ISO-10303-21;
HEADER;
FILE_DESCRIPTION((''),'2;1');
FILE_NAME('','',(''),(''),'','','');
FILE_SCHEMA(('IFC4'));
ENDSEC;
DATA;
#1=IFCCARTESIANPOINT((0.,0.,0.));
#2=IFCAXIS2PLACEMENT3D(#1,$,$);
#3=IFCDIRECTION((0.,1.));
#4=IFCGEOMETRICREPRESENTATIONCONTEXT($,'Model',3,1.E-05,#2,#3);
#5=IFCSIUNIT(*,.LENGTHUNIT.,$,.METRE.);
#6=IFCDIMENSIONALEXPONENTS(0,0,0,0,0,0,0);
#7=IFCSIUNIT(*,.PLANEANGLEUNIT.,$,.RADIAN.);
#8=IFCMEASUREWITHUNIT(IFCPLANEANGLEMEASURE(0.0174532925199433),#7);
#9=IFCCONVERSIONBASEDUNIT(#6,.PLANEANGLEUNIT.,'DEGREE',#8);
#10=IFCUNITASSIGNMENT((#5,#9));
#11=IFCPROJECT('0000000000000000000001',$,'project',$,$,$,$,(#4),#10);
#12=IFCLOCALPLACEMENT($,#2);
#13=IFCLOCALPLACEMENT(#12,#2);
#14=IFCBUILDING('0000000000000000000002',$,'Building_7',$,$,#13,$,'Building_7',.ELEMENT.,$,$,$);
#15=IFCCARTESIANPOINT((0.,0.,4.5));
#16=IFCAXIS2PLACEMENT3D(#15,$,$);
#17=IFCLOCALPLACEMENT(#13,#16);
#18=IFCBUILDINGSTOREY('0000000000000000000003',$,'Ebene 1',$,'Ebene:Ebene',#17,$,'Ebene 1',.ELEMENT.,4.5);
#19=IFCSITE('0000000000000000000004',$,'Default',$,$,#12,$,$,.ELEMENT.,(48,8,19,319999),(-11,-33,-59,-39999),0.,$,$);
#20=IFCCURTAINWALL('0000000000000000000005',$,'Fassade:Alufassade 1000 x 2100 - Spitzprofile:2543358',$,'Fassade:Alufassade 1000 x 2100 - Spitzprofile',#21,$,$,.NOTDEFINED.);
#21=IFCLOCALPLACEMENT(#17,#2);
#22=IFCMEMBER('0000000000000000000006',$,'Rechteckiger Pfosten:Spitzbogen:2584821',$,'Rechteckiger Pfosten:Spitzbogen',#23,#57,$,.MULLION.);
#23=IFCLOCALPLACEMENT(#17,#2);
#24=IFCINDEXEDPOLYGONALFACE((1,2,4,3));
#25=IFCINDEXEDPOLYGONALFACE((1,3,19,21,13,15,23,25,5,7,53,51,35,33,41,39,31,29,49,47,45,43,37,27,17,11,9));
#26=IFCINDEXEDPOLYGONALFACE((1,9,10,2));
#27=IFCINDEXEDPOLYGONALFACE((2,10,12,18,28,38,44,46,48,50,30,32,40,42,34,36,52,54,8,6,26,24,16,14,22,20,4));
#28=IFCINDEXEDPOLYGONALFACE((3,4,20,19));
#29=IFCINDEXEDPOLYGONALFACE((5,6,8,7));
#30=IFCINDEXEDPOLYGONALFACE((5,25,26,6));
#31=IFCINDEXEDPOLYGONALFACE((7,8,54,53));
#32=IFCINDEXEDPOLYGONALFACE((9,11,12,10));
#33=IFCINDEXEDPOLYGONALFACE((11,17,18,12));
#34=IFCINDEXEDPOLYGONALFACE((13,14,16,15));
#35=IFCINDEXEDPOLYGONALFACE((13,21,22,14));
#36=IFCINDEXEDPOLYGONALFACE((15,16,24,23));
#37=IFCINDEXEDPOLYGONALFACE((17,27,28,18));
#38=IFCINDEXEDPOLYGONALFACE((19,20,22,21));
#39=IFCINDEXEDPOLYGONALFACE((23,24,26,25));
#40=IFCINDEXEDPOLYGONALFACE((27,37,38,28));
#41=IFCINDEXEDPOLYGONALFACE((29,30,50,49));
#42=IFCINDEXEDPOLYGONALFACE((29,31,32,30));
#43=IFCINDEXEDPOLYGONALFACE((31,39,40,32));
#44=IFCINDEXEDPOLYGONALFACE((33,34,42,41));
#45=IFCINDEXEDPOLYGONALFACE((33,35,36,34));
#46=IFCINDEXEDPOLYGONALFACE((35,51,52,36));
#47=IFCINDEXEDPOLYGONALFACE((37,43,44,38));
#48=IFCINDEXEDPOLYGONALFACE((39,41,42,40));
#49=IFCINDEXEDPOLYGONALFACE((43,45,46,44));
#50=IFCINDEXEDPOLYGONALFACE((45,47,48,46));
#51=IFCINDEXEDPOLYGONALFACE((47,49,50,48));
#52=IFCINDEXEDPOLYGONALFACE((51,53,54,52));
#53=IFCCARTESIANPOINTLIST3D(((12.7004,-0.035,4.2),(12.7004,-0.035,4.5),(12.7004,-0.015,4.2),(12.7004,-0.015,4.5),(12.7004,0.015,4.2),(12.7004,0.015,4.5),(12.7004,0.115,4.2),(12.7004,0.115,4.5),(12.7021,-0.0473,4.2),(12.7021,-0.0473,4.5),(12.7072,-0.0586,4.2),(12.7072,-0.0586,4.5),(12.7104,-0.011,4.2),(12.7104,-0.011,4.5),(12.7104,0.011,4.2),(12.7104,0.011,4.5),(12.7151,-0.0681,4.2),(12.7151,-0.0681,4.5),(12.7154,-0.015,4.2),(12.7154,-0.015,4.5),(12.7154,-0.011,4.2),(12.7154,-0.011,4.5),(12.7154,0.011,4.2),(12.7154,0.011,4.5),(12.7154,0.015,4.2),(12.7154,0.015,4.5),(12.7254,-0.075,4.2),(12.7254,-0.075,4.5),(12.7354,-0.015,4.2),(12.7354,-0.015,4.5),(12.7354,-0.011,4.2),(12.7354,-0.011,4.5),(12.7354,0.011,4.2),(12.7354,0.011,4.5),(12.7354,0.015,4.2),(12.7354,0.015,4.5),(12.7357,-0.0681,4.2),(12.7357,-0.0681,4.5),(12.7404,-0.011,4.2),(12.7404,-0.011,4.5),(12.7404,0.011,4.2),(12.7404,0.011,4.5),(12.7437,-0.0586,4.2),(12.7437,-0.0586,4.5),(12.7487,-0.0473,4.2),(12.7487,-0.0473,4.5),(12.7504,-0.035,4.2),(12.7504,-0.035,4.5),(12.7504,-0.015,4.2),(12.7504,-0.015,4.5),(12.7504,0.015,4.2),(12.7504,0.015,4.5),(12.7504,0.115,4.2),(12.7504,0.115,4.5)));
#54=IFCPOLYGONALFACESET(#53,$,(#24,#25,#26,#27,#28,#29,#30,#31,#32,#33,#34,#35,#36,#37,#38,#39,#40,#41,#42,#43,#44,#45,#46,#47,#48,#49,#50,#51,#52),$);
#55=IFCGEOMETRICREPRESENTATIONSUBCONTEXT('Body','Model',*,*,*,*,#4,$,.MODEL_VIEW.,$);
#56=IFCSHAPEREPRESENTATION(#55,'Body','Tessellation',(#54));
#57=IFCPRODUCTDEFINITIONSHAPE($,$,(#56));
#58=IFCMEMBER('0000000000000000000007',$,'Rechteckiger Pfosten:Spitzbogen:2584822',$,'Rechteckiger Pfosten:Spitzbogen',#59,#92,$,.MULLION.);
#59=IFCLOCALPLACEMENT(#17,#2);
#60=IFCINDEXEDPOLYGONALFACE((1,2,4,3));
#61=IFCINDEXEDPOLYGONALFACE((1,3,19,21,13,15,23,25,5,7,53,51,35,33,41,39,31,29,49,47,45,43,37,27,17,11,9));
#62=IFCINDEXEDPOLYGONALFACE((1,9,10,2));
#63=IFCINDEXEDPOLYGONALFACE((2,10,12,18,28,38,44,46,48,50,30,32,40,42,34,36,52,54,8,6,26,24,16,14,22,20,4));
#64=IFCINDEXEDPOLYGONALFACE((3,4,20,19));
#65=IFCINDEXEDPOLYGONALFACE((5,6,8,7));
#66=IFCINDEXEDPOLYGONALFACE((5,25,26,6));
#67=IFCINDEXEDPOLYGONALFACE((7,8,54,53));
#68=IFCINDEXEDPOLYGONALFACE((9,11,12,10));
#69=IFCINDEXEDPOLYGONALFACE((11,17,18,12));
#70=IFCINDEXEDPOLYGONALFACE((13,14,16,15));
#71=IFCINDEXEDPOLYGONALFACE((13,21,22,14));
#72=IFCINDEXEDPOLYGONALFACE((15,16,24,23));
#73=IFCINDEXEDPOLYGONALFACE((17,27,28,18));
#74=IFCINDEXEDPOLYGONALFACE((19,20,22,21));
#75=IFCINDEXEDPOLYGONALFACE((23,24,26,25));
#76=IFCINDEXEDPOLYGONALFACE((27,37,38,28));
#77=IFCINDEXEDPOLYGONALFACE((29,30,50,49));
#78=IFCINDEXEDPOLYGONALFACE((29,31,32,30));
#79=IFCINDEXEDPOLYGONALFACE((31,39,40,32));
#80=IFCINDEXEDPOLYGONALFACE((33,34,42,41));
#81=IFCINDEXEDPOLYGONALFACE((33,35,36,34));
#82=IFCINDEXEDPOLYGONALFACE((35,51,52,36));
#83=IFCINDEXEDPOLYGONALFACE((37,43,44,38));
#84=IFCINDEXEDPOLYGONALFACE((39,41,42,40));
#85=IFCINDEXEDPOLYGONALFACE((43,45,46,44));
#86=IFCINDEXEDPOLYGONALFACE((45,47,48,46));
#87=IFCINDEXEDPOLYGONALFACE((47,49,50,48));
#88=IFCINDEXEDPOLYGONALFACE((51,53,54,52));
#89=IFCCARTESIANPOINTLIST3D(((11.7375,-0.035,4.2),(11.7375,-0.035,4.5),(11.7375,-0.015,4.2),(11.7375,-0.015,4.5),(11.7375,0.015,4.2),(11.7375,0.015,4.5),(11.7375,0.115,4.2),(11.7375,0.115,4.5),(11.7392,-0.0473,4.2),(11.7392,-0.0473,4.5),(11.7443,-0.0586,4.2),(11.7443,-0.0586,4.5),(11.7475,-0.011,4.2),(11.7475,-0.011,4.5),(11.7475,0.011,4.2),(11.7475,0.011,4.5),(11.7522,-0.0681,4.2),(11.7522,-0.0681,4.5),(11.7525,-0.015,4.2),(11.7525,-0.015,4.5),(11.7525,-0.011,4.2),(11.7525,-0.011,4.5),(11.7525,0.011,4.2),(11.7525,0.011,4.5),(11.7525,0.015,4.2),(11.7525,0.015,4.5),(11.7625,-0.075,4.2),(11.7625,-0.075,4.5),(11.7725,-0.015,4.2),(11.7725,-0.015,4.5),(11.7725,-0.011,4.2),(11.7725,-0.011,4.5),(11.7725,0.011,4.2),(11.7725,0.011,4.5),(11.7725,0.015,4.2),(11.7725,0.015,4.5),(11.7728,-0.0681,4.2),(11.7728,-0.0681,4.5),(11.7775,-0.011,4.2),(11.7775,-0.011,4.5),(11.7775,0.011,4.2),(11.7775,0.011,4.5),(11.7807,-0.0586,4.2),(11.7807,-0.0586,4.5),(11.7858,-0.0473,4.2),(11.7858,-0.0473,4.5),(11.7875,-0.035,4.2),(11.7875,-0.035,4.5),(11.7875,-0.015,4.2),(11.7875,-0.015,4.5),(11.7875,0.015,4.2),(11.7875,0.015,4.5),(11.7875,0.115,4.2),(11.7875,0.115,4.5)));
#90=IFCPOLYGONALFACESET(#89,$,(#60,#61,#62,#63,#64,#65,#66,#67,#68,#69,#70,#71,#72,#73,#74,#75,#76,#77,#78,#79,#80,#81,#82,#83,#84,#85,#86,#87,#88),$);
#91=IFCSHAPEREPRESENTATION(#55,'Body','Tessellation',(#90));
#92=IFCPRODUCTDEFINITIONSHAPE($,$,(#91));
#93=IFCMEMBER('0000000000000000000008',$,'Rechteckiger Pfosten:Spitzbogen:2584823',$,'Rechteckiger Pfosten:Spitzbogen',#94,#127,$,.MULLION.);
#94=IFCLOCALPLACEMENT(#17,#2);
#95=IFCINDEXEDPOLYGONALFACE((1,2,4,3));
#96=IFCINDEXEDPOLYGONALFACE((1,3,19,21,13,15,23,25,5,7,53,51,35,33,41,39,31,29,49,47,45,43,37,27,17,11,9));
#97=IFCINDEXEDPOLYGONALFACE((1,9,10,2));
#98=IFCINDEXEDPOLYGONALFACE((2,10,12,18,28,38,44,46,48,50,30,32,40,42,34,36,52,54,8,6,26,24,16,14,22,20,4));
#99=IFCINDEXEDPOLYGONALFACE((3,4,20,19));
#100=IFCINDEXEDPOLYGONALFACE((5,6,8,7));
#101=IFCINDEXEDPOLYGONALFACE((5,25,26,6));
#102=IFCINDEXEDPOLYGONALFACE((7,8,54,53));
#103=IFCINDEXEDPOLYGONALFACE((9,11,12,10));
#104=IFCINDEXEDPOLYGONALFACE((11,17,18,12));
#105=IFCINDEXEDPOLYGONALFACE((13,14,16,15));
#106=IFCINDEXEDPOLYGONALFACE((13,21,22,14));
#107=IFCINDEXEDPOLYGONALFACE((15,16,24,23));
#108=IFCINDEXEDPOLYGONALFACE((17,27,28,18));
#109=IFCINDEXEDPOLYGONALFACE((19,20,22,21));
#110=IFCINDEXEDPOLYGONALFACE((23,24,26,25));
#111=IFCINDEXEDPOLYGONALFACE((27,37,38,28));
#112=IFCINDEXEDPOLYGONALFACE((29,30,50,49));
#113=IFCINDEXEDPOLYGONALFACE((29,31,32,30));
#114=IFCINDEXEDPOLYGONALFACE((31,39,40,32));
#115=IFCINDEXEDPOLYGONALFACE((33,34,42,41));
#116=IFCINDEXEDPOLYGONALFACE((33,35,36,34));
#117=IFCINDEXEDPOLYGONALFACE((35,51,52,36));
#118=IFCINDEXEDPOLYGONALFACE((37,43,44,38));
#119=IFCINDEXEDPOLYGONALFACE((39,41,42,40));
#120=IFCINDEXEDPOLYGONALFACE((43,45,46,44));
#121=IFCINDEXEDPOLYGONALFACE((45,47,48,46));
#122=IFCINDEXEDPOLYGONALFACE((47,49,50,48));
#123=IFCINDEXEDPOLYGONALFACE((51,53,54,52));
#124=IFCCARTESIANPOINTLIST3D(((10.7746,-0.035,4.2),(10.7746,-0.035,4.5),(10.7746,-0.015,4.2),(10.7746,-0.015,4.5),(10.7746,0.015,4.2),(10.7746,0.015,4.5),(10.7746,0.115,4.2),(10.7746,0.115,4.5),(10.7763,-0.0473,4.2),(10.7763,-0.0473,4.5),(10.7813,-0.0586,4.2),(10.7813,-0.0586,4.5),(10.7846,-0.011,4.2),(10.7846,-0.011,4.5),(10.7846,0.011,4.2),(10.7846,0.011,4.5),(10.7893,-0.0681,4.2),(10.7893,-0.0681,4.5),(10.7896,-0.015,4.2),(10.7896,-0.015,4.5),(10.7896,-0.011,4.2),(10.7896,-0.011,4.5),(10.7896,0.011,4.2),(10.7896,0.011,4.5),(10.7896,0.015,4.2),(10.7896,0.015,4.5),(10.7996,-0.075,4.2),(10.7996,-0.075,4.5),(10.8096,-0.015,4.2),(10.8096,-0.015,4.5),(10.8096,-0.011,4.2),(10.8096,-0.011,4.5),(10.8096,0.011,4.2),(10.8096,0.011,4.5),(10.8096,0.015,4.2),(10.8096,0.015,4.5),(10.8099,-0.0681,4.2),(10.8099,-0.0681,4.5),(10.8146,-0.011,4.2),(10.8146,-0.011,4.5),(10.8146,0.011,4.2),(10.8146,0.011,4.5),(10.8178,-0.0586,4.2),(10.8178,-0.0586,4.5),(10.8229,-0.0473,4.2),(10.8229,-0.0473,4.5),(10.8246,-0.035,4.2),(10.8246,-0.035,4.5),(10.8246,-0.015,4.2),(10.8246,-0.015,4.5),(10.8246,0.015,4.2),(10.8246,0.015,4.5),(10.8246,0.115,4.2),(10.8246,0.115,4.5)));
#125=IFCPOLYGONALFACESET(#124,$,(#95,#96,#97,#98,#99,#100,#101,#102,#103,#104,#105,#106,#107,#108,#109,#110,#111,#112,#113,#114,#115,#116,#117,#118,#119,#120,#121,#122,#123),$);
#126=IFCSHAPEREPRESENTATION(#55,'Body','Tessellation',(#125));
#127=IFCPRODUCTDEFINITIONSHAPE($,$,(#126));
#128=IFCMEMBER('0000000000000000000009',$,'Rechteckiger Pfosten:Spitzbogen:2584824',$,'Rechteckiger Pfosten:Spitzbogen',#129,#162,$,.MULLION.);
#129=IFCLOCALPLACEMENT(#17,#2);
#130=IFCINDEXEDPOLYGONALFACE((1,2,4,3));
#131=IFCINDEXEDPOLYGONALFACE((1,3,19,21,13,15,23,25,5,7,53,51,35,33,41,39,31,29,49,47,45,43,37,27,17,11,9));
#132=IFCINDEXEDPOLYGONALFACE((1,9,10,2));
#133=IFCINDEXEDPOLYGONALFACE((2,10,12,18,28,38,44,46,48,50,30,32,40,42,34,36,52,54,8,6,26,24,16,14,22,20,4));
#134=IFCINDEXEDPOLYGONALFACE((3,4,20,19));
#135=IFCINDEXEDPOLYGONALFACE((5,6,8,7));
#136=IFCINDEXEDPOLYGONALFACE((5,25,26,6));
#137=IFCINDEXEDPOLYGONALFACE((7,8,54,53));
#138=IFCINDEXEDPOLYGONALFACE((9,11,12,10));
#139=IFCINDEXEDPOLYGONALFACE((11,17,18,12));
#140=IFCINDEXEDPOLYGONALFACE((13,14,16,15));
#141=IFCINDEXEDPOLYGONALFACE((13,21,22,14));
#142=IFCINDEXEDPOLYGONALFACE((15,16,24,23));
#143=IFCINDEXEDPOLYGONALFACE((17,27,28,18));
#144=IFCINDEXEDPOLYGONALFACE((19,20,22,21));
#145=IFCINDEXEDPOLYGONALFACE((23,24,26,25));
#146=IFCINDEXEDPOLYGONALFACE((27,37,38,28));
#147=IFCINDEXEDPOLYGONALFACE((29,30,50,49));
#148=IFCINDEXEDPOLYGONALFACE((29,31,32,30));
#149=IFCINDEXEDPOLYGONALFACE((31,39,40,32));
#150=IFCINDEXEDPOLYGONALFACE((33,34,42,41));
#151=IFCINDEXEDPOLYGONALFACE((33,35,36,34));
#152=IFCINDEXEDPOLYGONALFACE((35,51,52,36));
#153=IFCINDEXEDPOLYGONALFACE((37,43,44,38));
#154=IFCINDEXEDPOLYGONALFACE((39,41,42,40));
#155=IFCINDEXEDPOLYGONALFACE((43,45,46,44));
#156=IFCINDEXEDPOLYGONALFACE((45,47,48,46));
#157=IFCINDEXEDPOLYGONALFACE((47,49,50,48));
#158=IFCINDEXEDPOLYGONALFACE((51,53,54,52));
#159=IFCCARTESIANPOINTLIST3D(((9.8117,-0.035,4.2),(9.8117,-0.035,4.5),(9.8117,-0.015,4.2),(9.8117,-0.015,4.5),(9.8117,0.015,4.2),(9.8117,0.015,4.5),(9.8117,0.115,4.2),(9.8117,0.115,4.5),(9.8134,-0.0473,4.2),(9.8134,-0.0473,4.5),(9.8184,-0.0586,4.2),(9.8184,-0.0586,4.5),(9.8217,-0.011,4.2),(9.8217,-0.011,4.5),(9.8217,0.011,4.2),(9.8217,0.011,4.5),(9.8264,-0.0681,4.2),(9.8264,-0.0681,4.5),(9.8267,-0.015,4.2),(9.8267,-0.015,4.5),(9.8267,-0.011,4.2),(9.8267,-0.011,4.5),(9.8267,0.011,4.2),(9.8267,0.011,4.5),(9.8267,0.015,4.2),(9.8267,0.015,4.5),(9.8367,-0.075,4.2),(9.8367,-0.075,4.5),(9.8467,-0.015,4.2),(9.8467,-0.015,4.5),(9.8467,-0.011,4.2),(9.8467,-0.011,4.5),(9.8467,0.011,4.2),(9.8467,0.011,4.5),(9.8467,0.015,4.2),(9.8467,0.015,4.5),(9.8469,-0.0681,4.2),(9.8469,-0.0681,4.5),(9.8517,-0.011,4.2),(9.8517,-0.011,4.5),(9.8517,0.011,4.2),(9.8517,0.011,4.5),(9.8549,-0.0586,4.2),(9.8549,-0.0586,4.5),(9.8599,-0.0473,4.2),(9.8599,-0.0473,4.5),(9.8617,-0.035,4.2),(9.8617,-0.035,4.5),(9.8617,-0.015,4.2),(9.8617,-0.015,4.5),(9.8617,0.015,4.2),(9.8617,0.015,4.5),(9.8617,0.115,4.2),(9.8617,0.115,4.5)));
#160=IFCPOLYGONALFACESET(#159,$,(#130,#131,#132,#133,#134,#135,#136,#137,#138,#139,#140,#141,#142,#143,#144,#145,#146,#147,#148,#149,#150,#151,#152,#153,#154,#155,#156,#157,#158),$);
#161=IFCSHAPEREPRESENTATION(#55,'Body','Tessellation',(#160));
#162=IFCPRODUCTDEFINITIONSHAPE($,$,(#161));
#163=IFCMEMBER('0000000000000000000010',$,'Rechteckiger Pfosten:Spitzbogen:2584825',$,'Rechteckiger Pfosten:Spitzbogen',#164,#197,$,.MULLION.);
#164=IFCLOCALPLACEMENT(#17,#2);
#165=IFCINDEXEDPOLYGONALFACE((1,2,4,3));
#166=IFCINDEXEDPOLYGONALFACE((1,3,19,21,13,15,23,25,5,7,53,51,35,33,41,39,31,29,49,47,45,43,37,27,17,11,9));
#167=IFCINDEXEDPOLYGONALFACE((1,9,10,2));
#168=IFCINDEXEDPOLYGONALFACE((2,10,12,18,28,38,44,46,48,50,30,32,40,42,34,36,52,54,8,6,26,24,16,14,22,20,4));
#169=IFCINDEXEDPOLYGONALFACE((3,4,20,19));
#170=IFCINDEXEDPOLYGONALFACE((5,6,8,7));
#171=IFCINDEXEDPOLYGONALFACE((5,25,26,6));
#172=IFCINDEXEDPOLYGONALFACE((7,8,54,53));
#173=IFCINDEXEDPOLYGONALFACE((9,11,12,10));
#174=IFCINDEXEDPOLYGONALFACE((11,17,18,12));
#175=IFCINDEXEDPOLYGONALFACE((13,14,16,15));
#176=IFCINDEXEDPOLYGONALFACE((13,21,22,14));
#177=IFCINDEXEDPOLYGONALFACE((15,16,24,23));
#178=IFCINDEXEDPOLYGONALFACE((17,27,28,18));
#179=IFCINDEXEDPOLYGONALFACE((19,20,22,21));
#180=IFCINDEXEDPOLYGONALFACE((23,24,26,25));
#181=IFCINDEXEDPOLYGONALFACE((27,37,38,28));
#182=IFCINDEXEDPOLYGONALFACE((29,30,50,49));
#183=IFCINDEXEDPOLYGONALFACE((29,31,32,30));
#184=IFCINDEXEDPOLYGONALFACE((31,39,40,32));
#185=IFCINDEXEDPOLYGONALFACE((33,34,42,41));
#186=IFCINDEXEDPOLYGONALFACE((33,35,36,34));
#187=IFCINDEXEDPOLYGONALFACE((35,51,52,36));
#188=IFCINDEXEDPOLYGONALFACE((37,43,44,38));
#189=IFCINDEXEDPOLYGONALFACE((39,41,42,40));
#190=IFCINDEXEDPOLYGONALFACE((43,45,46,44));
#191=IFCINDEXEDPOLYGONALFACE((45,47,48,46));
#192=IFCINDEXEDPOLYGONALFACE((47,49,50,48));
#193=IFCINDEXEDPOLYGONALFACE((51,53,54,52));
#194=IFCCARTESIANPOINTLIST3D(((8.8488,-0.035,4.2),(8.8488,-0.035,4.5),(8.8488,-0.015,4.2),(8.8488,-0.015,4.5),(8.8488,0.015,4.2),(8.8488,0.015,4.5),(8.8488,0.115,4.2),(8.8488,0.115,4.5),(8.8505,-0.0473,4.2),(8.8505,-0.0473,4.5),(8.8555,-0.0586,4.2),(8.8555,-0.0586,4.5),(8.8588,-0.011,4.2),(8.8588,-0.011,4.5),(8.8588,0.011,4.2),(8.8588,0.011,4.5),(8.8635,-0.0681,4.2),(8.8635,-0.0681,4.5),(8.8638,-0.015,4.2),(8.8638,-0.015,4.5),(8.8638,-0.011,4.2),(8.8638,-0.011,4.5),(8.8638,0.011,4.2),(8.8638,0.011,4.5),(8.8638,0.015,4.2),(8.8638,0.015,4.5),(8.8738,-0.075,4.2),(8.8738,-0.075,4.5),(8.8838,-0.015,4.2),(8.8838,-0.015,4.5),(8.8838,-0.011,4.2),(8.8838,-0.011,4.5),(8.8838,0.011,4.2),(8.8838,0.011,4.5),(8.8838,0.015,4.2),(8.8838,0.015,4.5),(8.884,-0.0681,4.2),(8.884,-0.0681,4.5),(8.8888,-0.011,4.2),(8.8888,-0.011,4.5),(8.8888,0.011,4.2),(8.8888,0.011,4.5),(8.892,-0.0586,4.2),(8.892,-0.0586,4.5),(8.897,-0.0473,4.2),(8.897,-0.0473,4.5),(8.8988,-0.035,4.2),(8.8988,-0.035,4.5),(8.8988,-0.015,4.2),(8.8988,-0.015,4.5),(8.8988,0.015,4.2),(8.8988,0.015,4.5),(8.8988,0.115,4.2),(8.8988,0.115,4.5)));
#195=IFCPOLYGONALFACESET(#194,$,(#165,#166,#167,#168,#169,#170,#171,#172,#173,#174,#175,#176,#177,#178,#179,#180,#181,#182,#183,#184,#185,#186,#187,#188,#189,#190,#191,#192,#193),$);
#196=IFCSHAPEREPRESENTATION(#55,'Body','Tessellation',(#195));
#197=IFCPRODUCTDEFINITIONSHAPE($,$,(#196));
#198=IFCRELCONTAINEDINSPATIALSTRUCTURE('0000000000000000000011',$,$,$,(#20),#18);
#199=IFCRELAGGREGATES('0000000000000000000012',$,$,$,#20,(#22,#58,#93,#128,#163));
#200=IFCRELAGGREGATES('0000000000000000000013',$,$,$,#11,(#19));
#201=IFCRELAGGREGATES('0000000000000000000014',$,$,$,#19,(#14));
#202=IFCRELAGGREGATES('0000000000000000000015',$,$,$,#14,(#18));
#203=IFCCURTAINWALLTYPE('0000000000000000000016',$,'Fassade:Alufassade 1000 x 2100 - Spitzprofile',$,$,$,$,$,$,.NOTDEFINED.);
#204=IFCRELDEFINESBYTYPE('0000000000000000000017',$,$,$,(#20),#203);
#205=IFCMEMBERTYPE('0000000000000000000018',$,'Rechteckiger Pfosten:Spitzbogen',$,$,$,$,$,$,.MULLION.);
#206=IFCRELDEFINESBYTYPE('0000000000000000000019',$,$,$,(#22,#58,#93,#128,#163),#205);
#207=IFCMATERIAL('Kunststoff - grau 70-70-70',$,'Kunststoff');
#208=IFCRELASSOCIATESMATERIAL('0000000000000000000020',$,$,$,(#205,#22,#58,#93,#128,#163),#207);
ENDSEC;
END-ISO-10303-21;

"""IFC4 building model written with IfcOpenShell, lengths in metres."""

from ifc_helpers import new_model, entity, si_unit, converted_unit, direction, frame, origin, place, context, subcontext, project, spatial, line, arc, indexed_curve, outline, extrude, source, transform, mapped, material, type_object, type_shapes, element, aggregate, save


model = new_model("IFC4")

# Units and contexts
model_context = context("Model", 3, precision=1e-05, world=origin(), true_north=direction((0.0, 1.0)))
body_context = subcontext(model_context, "Body", "Model", "MODEL_VIEW")
ifc_project = project(units=[si_unit("LENGTHUNIT", "METRE"), converted_unit("PLANEANGLEUNIT", "DEGREE", entity("IfcPlaneAngleMeasure", 0.0174532925199433), si_unit("PLANEANGLEUNIT", "RADIAN"), dimensions=[0, 0, 0, 0, 0, 0, 0])], contexts=[model_context])

# Site, building, storey
site_placement = place(None, origin())
site = spatial("IfcSite", under=ifc_project, at=site_placement, Name="Default", CompositionType="ELEMENT", RefLatitude=(48, 8, 19, 319999), RefLongitude=(-11, -33, -59, -39999), RefElevation=0.0)
building_placement = place(site_placement, origin())
building = spatial("IfcBuilding", under=site, at=building_placement, Name="Building_7", LongName="Building_7", CompositionType="ELEMENT")
storey_placement = place(building_placement, frame((0.0, 0.0, 4.5)))
storey = spatial("IfcBuildingStorey", under=building, at=storey_placement, Name="Ebene 1", ObjectType="Ebene:Ebene", LongName="Ebene 1", CompositionType="ELEMENT", Elevation=4.5)

# Curtain wall, members
curtain_wall_type = type_object("IfcCurtainWallType", Name="Fassade:Alufassade 1000 x 2100 - Spitzprofile", PredefinedType="NOTDEFINED")
curtain_wall_placement = place(storey_placement, frame((0.0, 0.0, -4.5)))
curtain_wall = element("IfcCurtainWall", 1, at=curtain_wall_placement, inside=storey, type_object=curtain_wall_type, Name="Fassade:Alufassade 1000 x 2100 - Spitzprofile:2543358", ObjectType="Fassade:Alufassade 1000 x 2100 - Spitzprofile", PredefinedType="NOTDEFINED")
ifc_material_1 = material(Name="Kunststoff - grau 70-70-70", Category="Kunststoff")
member_type_1 = type_object("IfcMemberType", Name="Rechteckiger Pfosten:Spitzbogen", PredefinedType="MULLION", material=ifc_material_1)
shared_shape_1 = source(origin(), body_context, "Body", "SweptSolid", [
    extrude(outline(indexed_curve([(-0.111, -0.025), (-0.011, -0.025), (-0.011, -0.01), (-0.007, -0.01), (-0.007, -0.015), (0.015, -0.015), (0.015, -0.01), (0.019, -0.01), (0.019, -0.025), (0.039, -0.025), (0.0626, -0.0182), (0.079, 0.0), (0.0626, 0.0182), (0.039, 0.025), (0.019, 0.025), (0.019, 0.01), (0.015, 0.01), (0.015, 0.015), (-0.007, 0.015), (-0.007, 0.01), (-0.011, 0.01), (-0.011, 0.025), (-0.111, 0.025)], segments=[line(1, 2, 3, 4, 5, 6, 7, 8, 9, 10), arc(10, 11, 12), arc(12, 13, 14), line(14, 15, 16, 17, 18, 19, 20, 21, 22, 23, 1)], self_intersect=False)), frame((0.0, 0.004, -0.3), z_axis=(0.0, 0.0, 1.0), x_axis=(0.0, -1.0, 0.0)), (0.0, 0.0, 1.0), 0.3),
])
type_shapes(member_type_1, [shared_shape_1])
member_1_placement = place(curtain_wall_placement, frame((12.7254, 0.0, 8.7), z_axis=(0.0, 0.0, -1.0), x_axis=(-1.0, 0.0, 0.0)))
member_1 = element("IfcMember", 2, at=member_1_placement, type_object=member_type_1, material=ifc_material_1, Name="Rechteckiger Pfosten:Spitzbogen:2584821", ObjectType="Rechteckiger Pfosten:Spitzbogen", PredefinedType="MULLION", context=body_context, shape_type="MappedRepresentation", body=[
    mapped(shared_shape_1, transform((0.0, 0.0, 0.0), scale=1.0)),
])
member_2_placement = place(curtain_wall_placement, frame((11.7625, 0.0, 8.7), z_axis=(0.0, 0.0, -1.0), x_axis=(-1.0, 0.0, 0.0)))
member_2 = element("IfcMember", 3, at=member_2_placement, type_object=member_type_1, material=ifc_material_1, Name="Rechteckiger Pfosten:Spitzbogen:2584822", ObjectType="Rechteckiger Pfosten:Spitzbogen", PredefinedType="MULLION", context=body_context, shape_type="MappedRepresentation", body=[
    mapped(shared_shape_1, transform((0.0, 0.0, 0.0), scale=1.0)),
])
member_3_placement = place(curtain_wall_placement, frame((10.7996, 0.0, 8.7), z_axis=(0.0, 0.0, -1.0), x_axis=(-1.0, 0.0, 0.0)))
member_3 = element("IfcMember", 4, at=member_3_placement, type_object=member_type_1, material=ifc_material_1, Name="Rechteckiger Pfosten:Spitzbogen:2584823", ObjectType="Rechteckiger Pfosten:Spitzbogen", PredefinedType="MULLION", context=body_context, shape_type="MappedRepresentation", body=[
    mapped(shared_shape_1, transform((0.0, 0.0, 0.0), scale=1.0)),
])
member_4_placement = place(curtain_wall_placement, frame((9.8367, 0.0, 8.7), z_axis=(0.0, 0.0, -1.0), x_axis=(-1.0, 0.0, 0.0)))
member_4 = element("IfcMember", 5, at=member_4_placement, type_object=member_type_1, material=ifc_material_1, Name="Rechteckiger Pfosten:Spitzbogen:2584824", ObjectType="Rechteckiger Pfosten:Spitzbogen", PredefinedType="MULLION", context=body_context, shape_type="MappedRepresentation", body=[
    mapped(shared_shape_1, transform((0.0, 0.0, 0.0), scale=1.0)),
])
member_5_placement = place(curtain_wall_placement, frame((8.8738, 0.0, 8.7), z_axis=(0.0, 0.0, -1.0), x_axis=(-1.0, 0.0, 0.0)))
member_5 = element("IfcMember", 6, at=member_5_placement, type_object=member_type_1, material=ifc_material_1, Name="Rechteckiger Pfosten:Spitzbogen:2584825", ObjectType="Rechteckiger Pfosten:Spitzbogen", PredefinedType="MULLION", context=body_context, shape_type="MappedRepresentation", body=[
    mapped(shared_shape_1, transform((0.0, 0.0, 0.0), scale=1.0)),
])
aggregate(curtain_wall, [member_1, member_2, member_3, member_4, member_5])

save(model, "model.ifc")
